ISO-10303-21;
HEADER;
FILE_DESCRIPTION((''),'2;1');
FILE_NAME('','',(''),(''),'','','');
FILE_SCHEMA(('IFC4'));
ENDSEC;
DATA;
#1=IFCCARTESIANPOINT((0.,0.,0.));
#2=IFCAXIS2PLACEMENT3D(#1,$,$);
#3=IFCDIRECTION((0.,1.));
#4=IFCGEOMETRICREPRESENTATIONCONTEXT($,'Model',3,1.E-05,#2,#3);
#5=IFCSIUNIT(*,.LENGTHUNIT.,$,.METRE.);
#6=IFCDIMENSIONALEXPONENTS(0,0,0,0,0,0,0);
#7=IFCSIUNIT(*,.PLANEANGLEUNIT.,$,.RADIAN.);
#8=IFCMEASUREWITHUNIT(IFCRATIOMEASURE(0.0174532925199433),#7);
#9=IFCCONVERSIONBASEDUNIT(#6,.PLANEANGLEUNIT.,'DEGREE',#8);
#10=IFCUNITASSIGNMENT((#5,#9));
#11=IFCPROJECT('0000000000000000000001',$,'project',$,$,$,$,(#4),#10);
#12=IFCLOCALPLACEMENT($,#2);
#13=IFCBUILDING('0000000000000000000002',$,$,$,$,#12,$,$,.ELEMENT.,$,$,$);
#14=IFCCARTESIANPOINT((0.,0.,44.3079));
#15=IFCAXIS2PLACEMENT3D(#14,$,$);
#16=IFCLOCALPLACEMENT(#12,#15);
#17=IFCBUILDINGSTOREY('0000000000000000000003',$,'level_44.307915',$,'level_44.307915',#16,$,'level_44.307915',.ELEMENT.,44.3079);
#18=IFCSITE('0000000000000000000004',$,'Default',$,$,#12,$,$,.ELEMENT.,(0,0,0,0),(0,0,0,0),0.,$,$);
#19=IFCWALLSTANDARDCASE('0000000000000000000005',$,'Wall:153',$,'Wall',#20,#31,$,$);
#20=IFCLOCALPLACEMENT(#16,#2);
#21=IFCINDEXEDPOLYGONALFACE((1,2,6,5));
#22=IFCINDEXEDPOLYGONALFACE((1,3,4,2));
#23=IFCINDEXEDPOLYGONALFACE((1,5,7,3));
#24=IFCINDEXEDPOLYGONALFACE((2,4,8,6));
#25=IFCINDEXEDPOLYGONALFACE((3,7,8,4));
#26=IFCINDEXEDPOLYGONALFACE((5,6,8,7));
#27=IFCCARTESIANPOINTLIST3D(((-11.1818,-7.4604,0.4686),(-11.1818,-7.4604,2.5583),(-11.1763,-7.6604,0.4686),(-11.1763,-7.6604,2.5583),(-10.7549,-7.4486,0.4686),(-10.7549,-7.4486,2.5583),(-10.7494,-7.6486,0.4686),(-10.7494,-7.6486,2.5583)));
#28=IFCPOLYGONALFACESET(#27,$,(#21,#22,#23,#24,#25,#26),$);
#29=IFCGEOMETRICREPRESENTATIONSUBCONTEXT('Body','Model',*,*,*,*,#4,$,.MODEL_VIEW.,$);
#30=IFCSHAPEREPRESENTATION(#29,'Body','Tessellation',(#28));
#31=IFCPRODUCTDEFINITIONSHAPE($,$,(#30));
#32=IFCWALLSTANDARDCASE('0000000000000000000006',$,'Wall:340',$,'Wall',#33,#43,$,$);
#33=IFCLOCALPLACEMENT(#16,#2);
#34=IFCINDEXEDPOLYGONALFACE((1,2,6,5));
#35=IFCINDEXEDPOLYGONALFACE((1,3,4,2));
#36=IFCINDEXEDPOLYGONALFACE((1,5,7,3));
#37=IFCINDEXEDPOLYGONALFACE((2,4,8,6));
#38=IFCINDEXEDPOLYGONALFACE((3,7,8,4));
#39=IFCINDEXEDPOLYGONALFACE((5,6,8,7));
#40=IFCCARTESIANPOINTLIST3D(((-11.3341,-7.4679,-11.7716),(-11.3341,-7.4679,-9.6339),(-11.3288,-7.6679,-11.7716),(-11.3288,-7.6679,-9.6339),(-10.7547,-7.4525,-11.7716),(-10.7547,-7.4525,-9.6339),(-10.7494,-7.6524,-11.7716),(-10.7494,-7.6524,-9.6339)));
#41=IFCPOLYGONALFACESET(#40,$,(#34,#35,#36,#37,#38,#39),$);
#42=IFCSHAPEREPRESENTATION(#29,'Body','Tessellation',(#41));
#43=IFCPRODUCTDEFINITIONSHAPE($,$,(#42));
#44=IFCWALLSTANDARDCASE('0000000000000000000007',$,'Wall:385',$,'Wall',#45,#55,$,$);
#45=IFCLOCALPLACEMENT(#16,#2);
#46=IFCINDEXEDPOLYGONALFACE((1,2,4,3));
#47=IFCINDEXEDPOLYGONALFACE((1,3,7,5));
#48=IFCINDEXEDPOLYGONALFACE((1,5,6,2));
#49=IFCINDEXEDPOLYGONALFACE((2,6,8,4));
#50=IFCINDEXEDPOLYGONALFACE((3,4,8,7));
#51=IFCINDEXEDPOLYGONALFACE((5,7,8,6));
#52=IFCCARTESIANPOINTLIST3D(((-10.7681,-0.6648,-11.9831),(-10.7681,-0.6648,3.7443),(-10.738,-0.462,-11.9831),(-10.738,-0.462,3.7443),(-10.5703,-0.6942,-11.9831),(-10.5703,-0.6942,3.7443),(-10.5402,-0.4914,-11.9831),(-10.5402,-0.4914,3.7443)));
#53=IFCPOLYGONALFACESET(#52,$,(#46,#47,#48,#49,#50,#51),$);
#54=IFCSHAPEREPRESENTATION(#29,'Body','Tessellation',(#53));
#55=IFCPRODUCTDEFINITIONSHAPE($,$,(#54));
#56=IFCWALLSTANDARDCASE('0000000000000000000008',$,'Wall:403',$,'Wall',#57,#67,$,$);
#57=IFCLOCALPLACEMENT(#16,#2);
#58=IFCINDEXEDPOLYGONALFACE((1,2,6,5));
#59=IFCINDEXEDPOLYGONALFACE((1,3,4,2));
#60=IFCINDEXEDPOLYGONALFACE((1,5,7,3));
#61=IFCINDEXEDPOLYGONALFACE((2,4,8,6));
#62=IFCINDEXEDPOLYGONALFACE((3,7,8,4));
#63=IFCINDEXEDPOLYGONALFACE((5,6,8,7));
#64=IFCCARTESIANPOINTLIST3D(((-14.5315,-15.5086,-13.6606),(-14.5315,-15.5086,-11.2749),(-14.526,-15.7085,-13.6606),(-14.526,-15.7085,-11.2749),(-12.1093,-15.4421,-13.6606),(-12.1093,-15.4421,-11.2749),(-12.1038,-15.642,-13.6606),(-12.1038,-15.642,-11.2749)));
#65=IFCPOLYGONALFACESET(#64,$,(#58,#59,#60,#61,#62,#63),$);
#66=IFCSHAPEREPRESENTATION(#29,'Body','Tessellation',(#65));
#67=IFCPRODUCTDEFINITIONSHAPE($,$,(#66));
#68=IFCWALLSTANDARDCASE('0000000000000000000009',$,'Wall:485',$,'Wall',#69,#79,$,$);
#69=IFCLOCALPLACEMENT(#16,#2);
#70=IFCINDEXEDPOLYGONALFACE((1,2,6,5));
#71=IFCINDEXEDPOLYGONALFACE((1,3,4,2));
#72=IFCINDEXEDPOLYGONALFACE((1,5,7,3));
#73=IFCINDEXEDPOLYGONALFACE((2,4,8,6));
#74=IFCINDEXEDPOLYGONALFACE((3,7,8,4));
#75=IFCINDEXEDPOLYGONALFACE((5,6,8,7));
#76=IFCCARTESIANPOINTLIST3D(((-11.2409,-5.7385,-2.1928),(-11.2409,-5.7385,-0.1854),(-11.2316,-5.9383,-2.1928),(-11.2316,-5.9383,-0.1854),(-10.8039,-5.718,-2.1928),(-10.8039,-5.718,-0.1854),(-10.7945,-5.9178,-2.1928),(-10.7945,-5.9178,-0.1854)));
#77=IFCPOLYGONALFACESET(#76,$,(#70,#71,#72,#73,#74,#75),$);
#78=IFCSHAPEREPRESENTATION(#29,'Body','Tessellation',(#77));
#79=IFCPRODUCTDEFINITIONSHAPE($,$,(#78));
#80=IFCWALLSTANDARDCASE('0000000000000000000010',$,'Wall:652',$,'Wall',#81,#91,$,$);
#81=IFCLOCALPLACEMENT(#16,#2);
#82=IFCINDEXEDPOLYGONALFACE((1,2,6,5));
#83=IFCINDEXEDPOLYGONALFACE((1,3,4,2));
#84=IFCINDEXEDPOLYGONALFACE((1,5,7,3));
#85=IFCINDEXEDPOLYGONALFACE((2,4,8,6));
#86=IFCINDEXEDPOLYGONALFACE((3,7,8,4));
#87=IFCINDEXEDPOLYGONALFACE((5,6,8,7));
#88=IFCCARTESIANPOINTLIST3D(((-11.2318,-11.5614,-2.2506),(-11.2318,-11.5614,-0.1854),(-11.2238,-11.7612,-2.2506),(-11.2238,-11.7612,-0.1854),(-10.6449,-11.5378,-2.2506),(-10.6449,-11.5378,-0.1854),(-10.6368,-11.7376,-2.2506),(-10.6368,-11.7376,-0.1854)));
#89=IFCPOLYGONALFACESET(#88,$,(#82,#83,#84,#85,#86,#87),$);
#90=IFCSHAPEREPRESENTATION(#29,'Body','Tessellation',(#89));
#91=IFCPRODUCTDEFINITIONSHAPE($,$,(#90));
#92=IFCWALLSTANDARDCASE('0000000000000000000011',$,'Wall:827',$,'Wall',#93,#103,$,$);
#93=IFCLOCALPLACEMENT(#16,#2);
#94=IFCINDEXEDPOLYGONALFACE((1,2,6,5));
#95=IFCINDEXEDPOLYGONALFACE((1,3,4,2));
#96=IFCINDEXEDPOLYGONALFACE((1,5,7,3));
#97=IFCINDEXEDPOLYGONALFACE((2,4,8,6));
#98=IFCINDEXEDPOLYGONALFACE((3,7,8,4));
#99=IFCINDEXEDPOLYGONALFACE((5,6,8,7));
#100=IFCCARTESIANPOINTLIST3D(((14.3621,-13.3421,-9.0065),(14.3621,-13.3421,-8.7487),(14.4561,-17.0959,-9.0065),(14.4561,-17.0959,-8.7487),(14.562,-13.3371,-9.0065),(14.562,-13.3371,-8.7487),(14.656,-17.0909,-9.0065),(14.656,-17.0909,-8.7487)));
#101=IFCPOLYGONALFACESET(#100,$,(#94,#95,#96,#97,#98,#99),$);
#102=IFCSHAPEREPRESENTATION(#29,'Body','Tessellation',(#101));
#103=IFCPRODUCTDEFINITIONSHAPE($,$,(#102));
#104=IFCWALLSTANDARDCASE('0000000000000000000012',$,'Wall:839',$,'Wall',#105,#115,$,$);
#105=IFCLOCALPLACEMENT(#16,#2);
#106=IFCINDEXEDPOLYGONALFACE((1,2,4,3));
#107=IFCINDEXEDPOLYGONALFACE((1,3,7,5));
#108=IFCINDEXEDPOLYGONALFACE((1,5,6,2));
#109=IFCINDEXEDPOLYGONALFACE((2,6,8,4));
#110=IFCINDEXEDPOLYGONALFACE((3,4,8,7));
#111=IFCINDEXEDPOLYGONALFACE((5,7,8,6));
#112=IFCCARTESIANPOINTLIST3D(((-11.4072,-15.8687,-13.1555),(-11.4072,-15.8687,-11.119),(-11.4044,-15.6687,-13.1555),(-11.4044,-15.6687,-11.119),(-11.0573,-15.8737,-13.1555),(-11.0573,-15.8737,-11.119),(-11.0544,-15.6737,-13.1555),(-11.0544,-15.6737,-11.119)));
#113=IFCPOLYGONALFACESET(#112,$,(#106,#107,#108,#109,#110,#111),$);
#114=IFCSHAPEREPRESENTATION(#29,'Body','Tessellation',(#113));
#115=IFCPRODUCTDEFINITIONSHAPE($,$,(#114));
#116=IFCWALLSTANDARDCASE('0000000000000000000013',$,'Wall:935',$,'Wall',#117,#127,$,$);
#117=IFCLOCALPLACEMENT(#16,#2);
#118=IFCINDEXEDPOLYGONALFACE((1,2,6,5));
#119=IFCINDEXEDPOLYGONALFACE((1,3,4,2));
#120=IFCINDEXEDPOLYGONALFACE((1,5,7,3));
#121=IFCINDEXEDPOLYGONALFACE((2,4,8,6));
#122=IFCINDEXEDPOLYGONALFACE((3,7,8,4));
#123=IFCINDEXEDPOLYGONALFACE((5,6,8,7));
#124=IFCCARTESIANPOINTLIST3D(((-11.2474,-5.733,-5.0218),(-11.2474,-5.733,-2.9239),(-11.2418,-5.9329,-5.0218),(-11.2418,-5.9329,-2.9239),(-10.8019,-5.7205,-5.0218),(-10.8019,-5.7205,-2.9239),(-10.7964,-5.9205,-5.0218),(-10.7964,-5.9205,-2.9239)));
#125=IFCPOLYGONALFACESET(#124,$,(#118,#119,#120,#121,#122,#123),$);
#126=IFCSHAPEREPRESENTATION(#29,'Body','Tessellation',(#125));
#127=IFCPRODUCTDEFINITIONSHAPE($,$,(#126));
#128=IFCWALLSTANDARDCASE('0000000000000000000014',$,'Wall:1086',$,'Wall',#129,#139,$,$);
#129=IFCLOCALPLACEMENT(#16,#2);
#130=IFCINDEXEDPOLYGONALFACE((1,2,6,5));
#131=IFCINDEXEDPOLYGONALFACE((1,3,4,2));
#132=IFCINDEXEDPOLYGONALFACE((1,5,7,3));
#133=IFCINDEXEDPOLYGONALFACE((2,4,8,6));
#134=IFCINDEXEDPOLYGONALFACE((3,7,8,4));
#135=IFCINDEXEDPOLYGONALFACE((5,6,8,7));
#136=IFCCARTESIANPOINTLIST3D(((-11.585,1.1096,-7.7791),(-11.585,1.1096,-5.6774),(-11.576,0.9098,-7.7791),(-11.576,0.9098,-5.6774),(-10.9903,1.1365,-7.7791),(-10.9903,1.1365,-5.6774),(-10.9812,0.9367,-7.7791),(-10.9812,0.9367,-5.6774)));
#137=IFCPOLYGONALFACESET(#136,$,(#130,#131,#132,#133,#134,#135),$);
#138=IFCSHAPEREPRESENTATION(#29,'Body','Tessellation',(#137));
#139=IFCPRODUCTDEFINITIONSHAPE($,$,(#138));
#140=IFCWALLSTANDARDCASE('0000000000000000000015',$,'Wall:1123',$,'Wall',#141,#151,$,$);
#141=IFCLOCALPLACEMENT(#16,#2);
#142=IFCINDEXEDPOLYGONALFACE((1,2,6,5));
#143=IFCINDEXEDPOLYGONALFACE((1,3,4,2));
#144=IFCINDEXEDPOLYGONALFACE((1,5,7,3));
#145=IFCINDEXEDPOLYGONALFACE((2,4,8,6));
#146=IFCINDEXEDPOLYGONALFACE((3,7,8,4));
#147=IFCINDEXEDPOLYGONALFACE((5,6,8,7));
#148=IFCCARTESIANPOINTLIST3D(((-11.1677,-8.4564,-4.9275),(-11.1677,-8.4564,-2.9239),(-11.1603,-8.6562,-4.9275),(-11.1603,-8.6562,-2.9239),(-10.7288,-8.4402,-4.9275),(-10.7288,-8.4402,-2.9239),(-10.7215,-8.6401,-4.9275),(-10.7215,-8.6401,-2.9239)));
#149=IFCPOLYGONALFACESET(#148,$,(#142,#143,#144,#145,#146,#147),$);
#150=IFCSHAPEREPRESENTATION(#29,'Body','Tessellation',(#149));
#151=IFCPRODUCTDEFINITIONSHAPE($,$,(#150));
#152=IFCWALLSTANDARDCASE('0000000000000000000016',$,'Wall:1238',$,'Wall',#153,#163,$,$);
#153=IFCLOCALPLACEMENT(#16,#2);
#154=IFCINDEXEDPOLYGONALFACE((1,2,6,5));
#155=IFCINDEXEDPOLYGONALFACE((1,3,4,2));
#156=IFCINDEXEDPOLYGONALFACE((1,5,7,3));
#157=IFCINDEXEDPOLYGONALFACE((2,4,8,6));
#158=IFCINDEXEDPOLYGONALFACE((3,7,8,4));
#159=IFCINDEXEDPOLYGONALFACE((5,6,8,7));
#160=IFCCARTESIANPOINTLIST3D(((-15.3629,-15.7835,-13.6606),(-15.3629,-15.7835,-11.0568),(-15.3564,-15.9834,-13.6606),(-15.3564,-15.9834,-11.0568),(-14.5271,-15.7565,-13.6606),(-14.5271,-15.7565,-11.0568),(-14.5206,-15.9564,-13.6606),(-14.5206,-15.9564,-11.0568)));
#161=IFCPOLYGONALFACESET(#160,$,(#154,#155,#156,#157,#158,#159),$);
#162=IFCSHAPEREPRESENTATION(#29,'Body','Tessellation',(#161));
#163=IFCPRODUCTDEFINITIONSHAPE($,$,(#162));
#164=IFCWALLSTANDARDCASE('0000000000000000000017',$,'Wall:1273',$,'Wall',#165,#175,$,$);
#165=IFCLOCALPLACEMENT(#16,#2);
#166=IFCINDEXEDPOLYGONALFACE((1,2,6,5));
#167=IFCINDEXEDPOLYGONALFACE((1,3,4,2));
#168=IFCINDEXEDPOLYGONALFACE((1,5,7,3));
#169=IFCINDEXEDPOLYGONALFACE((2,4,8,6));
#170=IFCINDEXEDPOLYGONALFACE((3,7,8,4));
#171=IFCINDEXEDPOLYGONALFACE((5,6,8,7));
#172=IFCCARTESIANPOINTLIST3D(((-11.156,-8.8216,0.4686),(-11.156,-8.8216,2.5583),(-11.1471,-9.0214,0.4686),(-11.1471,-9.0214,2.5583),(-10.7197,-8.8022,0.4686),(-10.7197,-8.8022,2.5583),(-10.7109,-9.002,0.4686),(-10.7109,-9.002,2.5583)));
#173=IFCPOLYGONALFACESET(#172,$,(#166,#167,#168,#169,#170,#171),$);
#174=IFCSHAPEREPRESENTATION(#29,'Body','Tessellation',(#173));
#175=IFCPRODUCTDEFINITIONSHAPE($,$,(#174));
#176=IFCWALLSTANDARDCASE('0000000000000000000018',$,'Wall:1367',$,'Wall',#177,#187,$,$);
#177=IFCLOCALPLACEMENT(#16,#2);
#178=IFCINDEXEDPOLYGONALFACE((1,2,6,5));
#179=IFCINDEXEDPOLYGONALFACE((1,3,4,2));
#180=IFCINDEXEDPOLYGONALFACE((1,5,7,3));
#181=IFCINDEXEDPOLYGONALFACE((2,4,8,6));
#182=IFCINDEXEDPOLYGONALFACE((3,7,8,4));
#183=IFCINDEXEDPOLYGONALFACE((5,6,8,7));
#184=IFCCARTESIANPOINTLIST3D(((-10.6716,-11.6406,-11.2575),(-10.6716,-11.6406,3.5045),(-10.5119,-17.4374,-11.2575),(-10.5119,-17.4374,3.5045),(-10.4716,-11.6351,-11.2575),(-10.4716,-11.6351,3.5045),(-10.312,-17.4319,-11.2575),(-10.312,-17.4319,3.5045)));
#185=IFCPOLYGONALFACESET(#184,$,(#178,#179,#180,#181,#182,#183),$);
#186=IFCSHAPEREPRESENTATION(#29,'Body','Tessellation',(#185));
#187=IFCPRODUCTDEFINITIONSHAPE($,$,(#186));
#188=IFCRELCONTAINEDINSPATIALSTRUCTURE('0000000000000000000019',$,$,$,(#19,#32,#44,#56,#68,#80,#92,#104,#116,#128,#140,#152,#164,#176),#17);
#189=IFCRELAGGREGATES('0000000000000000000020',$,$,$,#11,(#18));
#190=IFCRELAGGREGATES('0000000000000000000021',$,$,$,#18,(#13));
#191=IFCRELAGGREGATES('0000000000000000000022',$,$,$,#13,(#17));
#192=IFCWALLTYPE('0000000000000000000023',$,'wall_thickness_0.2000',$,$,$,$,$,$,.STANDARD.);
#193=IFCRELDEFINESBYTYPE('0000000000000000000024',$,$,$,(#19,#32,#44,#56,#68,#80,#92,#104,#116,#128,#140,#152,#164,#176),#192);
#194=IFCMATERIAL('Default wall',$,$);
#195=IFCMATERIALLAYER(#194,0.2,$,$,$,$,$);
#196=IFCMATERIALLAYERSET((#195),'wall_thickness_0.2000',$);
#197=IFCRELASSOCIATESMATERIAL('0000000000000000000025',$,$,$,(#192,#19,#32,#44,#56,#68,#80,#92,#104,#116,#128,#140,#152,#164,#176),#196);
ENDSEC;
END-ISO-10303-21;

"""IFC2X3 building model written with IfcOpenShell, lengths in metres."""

from ifc_helpers import new_model, entity, si_unit, converted_unit, direction, frame, origin, place, context, subcontext, project, spatial, polyline, outline, extrude, material, layer, layer_set, layer_usage, type_object, element, save


model = new_model("IFC2X3")

# Units and contexts
model_context = context("Model", 3, precision=1e-05, world=origin(), true_north=direction((0.0, 1.0)))
body_context = subcontext(model_context, "Body", "Model", "MODEL_VIEW")
ifc_project = project(units=[si_unit("LENGTHUNIT", "METRE"), converted_unit("PLANEANGLEUNIT", "DEGREE", entity("IfcRatioMeasure", 0.0174532925199433), si_unit("PLANEANGLEUNIT", "RADIAN"), dimensions=[0, 0, 0, 0, 0, 0, 0])], contexts=[model_context])

# Site, building, storey
placement_1 = place(None, origin())
site = spatial("IfcSite", under=ifc_project, at=placement_1, Name="Default", CompositionType="ELEMENT", RefLatitude=(0, 0, 0, 0), RefLongitude=(0, 0, 0, 0), RefElevation=0.0)
building = spatial("IfcBuilding", under=site, at=placement_1, CompositionType="ELEMENT")
storey_placement = place(placement_1, frame((0.0, 0.0, 44.3079)))
storey = spatial("IfcBuildingStorey", under=building, at=storey_placement, Name="level_44.307915", ObjectType="level_44.307915", LongName="level_44.307915", CompositionType="ELEMENT", Elevation=44.3079)

# Walls
ifc_material_1 = material(Name="Default wall")
ifc_layer = layer(ifc_material_1, 0.2)
ifc_layer_set = layer_set([ifc_layer], Name="wall_thickness_0.2000")
ifc_layer_usage = layer_usage(ifc_layer_set, "AXIS2", "POSITIVE", -0.1)
wall_type = type_object("IfcWallType", Name="wall_thickness_0.2000", PredefinedType="STANDARD", material=ifc_layer_set)
placement_2 = place(placement_1, frame((0.0, 0.0, 44.7765)))
wall_1_placement = place(placement_2, frame((-10.7521, -7.5486, 0.0), z_axis=(0.0, 0.0, 1.0), x_axis=(-0.999617, -0.027674, 0.0)))
element("IfcWallStandardCase", 1, at=wall_1_placement, inside=storey, type_object=wall_type, material=ifc_layer_usage, Name="Wall:153", ObjectType="Wall", context=body_context, shape_type="SweptSolid", body=[
    extrude(outline(polyline([(0.4271, -0.1), (0.4271, 0.1), (0.0, 0.1), (0.0, -0.1), (0.4271, -0.1)])), origin(), (0.0, 0.0, 1.0), 2.0897),
])
placement_3 = place(placement_1, frame((0.0, 0.0, 32.5363)))
wall_2_placement = place(placement_3, frame((-10.752, -7.5525, 0.0), z_axis=(0.0, 0.0, 1.0), x_axis=(-0.999646, -0.026607, 0.0)))
element("IfcWallStandardCase", 2, at=wall_2_placement, inside=storey, type_object=wall_type, material=ifc_layer_usage, Name="Wall:340", ObjectType="Wall", context=body_context, shape_type="SweptSolid", body=[
    extrude(outline(polyline([(0.5796, -0.1), (0.5796, 0.1), (0.0, 0.1), (0.0, -0.1), (0.5796, -0.1)])), origin(), (0.0, 0.0, 1.0), 2.1378),
])
placement_4 = place(placement_1, frame((0.0, 0.0, 32.3248)))
wall_3_placement = place(placement_4, frame((-10.6391, -0.4767, 0.0), z_axis=(0.0, 0.0, 1.0), x_axis=(-0.147019, -0.989134, 0.0)))
element("IfcWallStandardCase", 3, at=wall_3_placement, inside=storey, type_object=wall_type, material=ifc_layer_usage, Name="Wall:385", ObjectType="Wall", context=body_context, shape_type="SweptSolid", body=[
    extrude(outline(polyline([(0.205, -0.1), (0.205, 0.1), (0.0, 0.1), (0.0, -0.1), (0.205, -0.1)])), origin(), (0.0, 0.0, 1.0), 15.7274),
])
placement_5 = place(placement_1, frame((0.0, 0.0, 30.6473)))
wall_4_placement = place(placement_5, frame((-12.1065, -15.542, 0.0), z_axis=(0.0, 0.0, 1.0), x_axis=(-0.999623, -0.027442, 0.0)))
element("IfcWallStandardCase", 4, at=wall_4_placement, inside=storey, type_object=wall_type, material=ifc_layer_usage, Name="Wall:403", ObjectType="Wall", context=body_context, shape_type="SweptSolid", body=[
    extrude(outline(polyline([(2.4232, -0.1), (2.4232, 0.1), (0.0, 0.1), (0.0, -0.1), (2.4232, -0.1)])), origin(), (0.0, 0.0, 1.0), 2.3856),
])
placement_6 = place(placement_1, frame((0.0, 0.0, 42.1151)))
wall_5_placement = place(placement_6, frame((-10.7992, -5.8179, 0.0), z_axis=(0.0, 0.0, 1.0), x_axis=(-0.998901, -0.04686, 0.0)))
element("IfcWallStandardCase", 5, at=wall_5_placement, inside=storey, type_object=wall_type, material=ifc_layer_usage, Name="Wall:485", ObjectType="Wall", context=body_context, shape_type="SweptSolid", body=[
    extrude(outline(polyline([(0.4375, -0.1), (0.4375, 0.1), (0.0, 0.1), (0.0, -0.1), (0.4375, -0.1)])), origin(), (0.0, 0.0, 1.0), 2.0074),
])
placement_7 = place(placement_1, frame((0.0, 0.0, 42.0573)))
wall_6_placement = place(placement_7, frame((-10.6409, -11.6377, 0.0), z_axis=(0.0, 0.0, 1.0), x_axis=(-0.999193, -0.040158, 0.0)))
element("IfcWallStandardCase", 6, at=wall_6_placement, inside=storey, type_object=wall_type, material=ifc_layer_usage, Name="Wall:652", ObjectType="Wall", context=body_context, shape_type="SweptSolid", body=[
    extrude(outline(polyline([(0.5874, -0.1), (0.5874, 0.1), (0.0, 0.1), (0.0, -0.1), (0.5874, -0.1)])), origin(), (0.0, 0.0, 1.0), 2.0652),
])
placement_8 = place(placement_1, frame((0.0, 0.0, 35.3014)))
wall_7_placement = place(placement_8, frame((14.4621, -13.3396, 0.0), z_axis=(0.0, 0.0, 1.0), x_axis=(0.025025, -0.999687, 0.0)))
element("IfcWallStandardCase", 7, at=wall_7_placement, inside=storey, type_object=wall_type, material=ifc_layer_usage, Name="Wall:827", ObjectType="Wall", context=body_context, shape_type="SweptSolid", body=[
    extrude(outline(polyline([(3.755, -0.1), (3.755, 0.1), (0.0, 0.1), (0.0, -0.1), (3.755, -0.1)])), origin(), (0.0, 0.0, 1.0), 0.2578),
])
placement_9 = place(placement_1, frame((0.0, 0.0, 31.1524)))
wall_8_placement = place(placement_9, frame((-11.0559, -15.7737, 0.0), z_axis=(0.0, 0.0, 1.0), x_axis=(-0.9999, 0.014128, 0.0)))
element("IfcWallStandardCase", 8, at=wall_8_placement, inside=storey, type_object=wall_type, material=ifc_layer_usage, Name="Wall:839", ObjectType="Wall", context=body_context, shape_type="SweptSolid", body=[
    extrude(outline(polyline([(0.35, -0.1), (0.35, 0.1), (0.0, 0.1), (0.0, -0.1), (0.35, -0.1)])), origin(), (0.0, 0.0, 1.0), 2.0365),
])
placement_10 = place(placement_1, frame((0.0, 0.0, 39.2861)))
wall_9_placement = place(placement_10, frame((-10.7992, -5.8205, 0.0), z_axis=(0.0, 0.0, 1.0), x_axis=(-0.999611, -0.027892, 0.0)))
element("IfcWallStandardCase", 9, at=wall_9_placement, inside=storey, type_object=wall_type, material=ifc_layer_usage, Name="Wall:935", ObjectType="Wall", context=body_context, shape_type="SweptSolid", body=[
    extrude(outline(polyline([(0.4456, -0.1), (0.4456, 0.1), (0.0, 0.1), (0.0, -0.1), (0.4456, -0.1)])), origin(), (0.0, 0.0, 1.0), 2.0979),
])
placement_11 = place(placement_1, frame((0.0, 0.0, 36.5288)))
wall_10_placement = place(placement_11, frame((-10.9857, 1.0366, 0.0), z_axis=(0.0, 0.0, 1.0), x_axis=(-0.998975, -0.045264, 0.0)))
element("IfcWallStandardCase", 10, at=wall_10_placement, inside=storey, type_object=wall_type, material=ifc_layer_usage, Name="Wall:1086", ObjectType="Wall", context=body_context, shape_type="SweptSolid", body=[
    extrude(outline(polyline([(0.5954, -0.1), (0.5954, 0.1), (0.0, 0.1), (0.0, -0.1), (0.5954, -0.1)])), origin(), (0.0, 0.0, 1.0), 2.1017),
])
placement_12 = place(placement_1, frame((0.0, 0.0, 39.3804)))
wall_11_placement = place(placement_12, frame((-10.7251, -8.5402, 0.0), z_axis=(0.0, 0.0, 1.0), x_axis=(-0.999324, -0.036767, 0.0)))
element("IfcWallStandardCase", 11, at=wall_11_placement, inside=storey, type_object=wall_type, material=ifc_layer_usage, Name="Wall:1123", ObjectType="Wall", context=body_context, shape_type="SweptSolid", body=[
    extrude(outline(polyline([(0.4392, -0.1), (0.4392, 0.1), (0.0, 0.1), (0.0, -0.1), (0.4392, -0.1)])), origin(), (0.0, 0.0, 1.0), 2.0036),
])
placement_13 = place(placement_1, frame((0.0, 0.0, 30.6473)))
wall_12_placement = place(placement_13, frame((-14.5238, -15.8565, 0.0), z_axis=(0.0, 0.0, 1.0), x_axis=(-0.99948, -0.032249, 0.0)))
element("IfcWallStandardCase", 12, at=wall_12_placement, inside=storey, type_object=wall_type, material=ifc_layer_usage, Name="Wall:1238", ObjectType="Wall", context=body_context, shape_type="SweptSolid", body=[
    extrude(outline(polyline([(0.8363, -0.1), (0.8363, 0.1), (0.0, 0.1), (0.0, -0.1), (0.8363, -0.1)])), origin(), (0.0, 0.0, 1.0), 2.6038),
])
placement_14 = place(placement_1, frame((0.0, 0.0, 44.7765)))
wall_13_placement = place(placement_14, frame((-10.7153, -8.9021, 0.0), z_axis=(0.0, 0.0, 1.0), x_axis=(-0.999018, -0.044313, 0.0)))
element("IfcWallStandardCase", 13, at=wall_13_placement, inside=storey, type_object=wall_type, material=ifc_layer_usage, Name="Wall:1273", ObjectType="Wall", context=body_context, shape_type="SweptSolid", body=[
    extrude(outline(polyline([(0.4367, -0.1), (0.4367, 0.1), (0.0, 0.1), (0.0, -0.1), (0.4367, -0.1)])), origin(), (0.0, 0.0, 1.0), 2.0897),
])
placement_15 = place(placement_1, frame((0.0, 0.0, 33.0504)))
wall_14_placement = place(placement_15, frame((-10.5716, -11.6379, 0.0), z_axis=(0.0, 0.0, 1.0), x_axis=(0.027536, -0.999621, 0.0)))
element("IfcWallStandardCase", 14, at=wall_14_placement, inside=storey, type_object=wall_type, material=ifc_layer_usage, Name="Wall:1367", ObjectType="Wall", context=body_context, shape_type="SweptSolid", body=[
    extrude(outline(polyline([(5.7989, -0.1), (5.7989, 0.1), (0.0, 0.1), (0.0, -0.1), (5.7989, -0.1)])), origin(), (0.0, 0.0, 1.0), 14.762),
])

save(model, "model.ifc")
